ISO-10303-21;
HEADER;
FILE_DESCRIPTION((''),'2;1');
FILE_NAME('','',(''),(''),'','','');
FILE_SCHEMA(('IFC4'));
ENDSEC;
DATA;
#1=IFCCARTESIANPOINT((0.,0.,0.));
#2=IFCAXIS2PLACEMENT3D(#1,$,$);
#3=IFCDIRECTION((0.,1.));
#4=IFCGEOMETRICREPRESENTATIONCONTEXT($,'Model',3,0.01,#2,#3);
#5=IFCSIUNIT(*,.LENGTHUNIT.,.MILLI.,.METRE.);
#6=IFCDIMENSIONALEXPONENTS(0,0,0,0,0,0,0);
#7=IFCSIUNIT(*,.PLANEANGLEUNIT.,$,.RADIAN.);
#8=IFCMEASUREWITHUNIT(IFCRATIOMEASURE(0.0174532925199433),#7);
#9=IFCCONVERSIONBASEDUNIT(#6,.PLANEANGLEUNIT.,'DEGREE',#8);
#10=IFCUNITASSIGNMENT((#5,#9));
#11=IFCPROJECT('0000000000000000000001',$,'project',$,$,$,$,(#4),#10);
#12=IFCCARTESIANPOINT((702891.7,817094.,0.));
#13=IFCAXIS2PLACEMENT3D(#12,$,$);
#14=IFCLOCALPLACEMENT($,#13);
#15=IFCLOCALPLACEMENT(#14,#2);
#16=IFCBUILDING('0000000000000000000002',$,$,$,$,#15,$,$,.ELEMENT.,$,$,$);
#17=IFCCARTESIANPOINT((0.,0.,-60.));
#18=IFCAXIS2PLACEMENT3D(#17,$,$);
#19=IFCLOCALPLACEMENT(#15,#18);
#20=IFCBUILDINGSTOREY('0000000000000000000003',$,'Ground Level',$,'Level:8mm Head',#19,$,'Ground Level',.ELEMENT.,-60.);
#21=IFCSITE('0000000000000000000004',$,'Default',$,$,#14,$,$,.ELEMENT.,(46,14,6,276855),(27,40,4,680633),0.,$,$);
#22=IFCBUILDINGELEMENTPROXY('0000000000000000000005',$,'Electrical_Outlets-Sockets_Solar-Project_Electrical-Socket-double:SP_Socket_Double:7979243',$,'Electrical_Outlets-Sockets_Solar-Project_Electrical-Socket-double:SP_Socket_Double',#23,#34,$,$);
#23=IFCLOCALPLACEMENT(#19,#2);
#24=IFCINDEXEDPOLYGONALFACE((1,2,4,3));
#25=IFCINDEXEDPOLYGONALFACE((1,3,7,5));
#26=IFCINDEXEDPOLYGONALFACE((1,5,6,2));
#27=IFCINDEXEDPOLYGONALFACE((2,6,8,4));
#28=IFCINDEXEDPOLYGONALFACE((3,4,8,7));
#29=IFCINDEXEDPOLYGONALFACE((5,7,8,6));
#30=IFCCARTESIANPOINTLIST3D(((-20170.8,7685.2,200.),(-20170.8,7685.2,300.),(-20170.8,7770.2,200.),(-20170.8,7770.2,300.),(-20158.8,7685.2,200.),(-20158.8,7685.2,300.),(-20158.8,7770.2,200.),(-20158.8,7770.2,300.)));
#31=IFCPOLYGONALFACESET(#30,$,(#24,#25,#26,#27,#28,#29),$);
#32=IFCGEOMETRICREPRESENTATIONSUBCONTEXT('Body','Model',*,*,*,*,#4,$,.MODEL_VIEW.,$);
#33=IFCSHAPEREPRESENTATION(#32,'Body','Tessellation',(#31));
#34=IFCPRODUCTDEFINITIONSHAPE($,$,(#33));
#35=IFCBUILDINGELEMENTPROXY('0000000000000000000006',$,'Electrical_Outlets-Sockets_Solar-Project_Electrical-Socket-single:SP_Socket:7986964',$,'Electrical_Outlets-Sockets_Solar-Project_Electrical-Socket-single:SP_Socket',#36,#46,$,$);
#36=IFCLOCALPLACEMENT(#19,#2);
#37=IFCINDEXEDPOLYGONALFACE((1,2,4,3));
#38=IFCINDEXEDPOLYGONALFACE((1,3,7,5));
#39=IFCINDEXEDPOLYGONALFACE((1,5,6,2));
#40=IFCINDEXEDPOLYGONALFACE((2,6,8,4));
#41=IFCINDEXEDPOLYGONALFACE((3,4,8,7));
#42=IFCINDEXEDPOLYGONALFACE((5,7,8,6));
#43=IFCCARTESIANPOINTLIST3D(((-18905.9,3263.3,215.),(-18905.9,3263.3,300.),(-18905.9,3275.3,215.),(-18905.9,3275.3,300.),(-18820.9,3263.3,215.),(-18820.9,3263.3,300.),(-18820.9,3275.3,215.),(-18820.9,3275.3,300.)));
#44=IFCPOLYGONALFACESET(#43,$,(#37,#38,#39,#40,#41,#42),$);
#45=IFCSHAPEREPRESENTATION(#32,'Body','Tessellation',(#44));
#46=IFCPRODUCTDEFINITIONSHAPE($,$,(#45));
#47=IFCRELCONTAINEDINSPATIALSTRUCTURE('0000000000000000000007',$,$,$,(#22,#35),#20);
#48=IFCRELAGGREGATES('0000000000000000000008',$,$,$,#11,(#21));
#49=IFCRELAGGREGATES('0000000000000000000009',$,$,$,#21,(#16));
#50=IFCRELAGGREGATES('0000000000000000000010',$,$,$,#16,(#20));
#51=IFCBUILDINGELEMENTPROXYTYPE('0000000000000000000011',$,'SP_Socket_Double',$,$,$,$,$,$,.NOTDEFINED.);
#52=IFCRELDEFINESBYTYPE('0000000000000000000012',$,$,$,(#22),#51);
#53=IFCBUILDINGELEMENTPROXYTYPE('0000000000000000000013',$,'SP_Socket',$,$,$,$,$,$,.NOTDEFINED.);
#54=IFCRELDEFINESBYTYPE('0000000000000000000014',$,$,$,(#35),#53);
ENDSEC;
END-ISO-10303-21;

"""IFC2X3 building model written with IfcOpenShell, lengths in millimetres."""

from ifc_helpers import new_model, entity, si_unit, converted_unit, direction, frame, origin, origin_2d_with_axis, place, context, subcontext, project, spatial, rectangle, extrude, source, transform, mapped, type_object, type_shapes, element, save


model = new_model("IFC2X3")

# Units and contexts
model_context = context("Model", 3, precision=0.01, world=origin(), true_north=direction((0.0, 1.0)))
body_context = subcontext(model_context, "Body", "Model", "MODEL_VIEW")
ifc_project = project(units=[si_unit("LENGTHUNIT", "METRE", prefix="MILLI"), converted_unit("PLANEANGLEUNIT", "DEGREE", entity("IfcRatioMeasure", 0.0174532925199433), si_unit("PLANEANGLEUNIT", "RADIAN"), dimensions=[0, 0, 0, 0, 0, 0, 0])], contexts=[model_context])

# Site, building, storey
site_placement = place(None, frame((702891.7, 817094.0, 0.0)))
site = spatial("IfcSite", under=ifc_project, at=site_placement, Name="Default", CompositionType="ELEMENT", RefLatitude=(46, 14, 6, 276855), RefLongitude=(27, 40, 4, 680633), RefElevation=0.0)
building_placement = place(site_placement, origin())
building = spatial("IfcBuilding", under=site, at=building_placement, CompositionType="ELEMENT")
storey_placement = place(building_placement, frame((0.0, 0.0, -60.0)))
storey = spatial("IfcBuildingStorey", under=building, at=storey_placement, Name="Ground Level", ObjectType="Level:8mm Head", LongName="Ground Level", CompositionType="ELEMENT", Elevation=-60.0)

# Building element proxies
building_element_proxy_type_1 = type_object("IfcBuildingElementProxyType", Name="SP_Socket_Double", PredefinedType="NOTDEFINED")
shared_shape_1 = source(origin(), body_context, "Body", "SweptSolid", [
    extrude(rectangle(XDim=12.0, YDim=85.0, at=origin_2d_with_axis()), frame((0.0, -6.0, -100.0), z_axis=(0.0, 0.0, 1.0), x_axis=(0.0, 1.0, 0.0)), (0.0, 0.0, 1.0), 100.0),
])
type_shapes(building_element_proxy_type_1, [shared_shape_1])
proxy_1_placement = place(storey_placement, frame((-20170.8, 7727.7, 300.0), z_axis=(0.0, 0.0, 1.0), x_axis=(0.0, 1.0, 0.0)))
element("IfcBuildingElementProxy", 1, at=proxy_1_placement, inside=storey, type_object=building_element_proxy_type_1, Name="Electrical_Outlets-Sockets_Solar-Project_Electrical-Socket-double:SP_Socket_Double:7979243", ObjectType="Electrical_Outlets-Sockets_Solar-Project_Electrical-Socket-double:SP_Socket_Double", context=body_context, shape_type="MappedRepresentation", body=[
    mapped(shared_shape_1, transform((0.0, 0.0, 0.0), scale=1.0)),
])
building_element_proxy_type_2 = type_object("IfcBuildingElementProxyType", Name="SP_Socket", PredefinedType="NOTDEFINED")
shared_shape_2 = source(origin(), body_context, "Body", "SweptSolid", [
    extrude(rectangle(XDim=12.0, YDim=85.0, at=origin_2d_with_axis()), frame((0.0, -6.0, -85.0), z_axis=(0.0, 0.0, 1.0), x_axis=(0.0, 1.0, 0.0)), (0.0, 0.0, 1.0), 85.0),
])
type_shapes(building_element_proxy_type_2, [shared_shape_2])
proxy_2_placement = place(storey_placement, frame((-18863.4, 3263.3, 300.0), z_axis=(0.0, 0.0, 1.0), x_axis=(-1.0, 0.0, 0.0)))
element("IfcBuildingElementProxy", 2, at=proxy_2_placement, inside=storey, type_object=building_element_proxy_type_2, Name="Electrical_Outlets-Sockets_Solar-Project_Electrical-Socket-single:SP_Socket:7986964", ObjectType="Electrical_Outlets-Sockets_Solar-Project_Electrical-Socket-single:SP_Socket", context=body_context, shape_type="MappedRepresentation", body=[
    mapped(shared_shape_2, transform((0.0, 0.0, 0.0), scale=1.0)),
])

save(model, "model.ifc")
